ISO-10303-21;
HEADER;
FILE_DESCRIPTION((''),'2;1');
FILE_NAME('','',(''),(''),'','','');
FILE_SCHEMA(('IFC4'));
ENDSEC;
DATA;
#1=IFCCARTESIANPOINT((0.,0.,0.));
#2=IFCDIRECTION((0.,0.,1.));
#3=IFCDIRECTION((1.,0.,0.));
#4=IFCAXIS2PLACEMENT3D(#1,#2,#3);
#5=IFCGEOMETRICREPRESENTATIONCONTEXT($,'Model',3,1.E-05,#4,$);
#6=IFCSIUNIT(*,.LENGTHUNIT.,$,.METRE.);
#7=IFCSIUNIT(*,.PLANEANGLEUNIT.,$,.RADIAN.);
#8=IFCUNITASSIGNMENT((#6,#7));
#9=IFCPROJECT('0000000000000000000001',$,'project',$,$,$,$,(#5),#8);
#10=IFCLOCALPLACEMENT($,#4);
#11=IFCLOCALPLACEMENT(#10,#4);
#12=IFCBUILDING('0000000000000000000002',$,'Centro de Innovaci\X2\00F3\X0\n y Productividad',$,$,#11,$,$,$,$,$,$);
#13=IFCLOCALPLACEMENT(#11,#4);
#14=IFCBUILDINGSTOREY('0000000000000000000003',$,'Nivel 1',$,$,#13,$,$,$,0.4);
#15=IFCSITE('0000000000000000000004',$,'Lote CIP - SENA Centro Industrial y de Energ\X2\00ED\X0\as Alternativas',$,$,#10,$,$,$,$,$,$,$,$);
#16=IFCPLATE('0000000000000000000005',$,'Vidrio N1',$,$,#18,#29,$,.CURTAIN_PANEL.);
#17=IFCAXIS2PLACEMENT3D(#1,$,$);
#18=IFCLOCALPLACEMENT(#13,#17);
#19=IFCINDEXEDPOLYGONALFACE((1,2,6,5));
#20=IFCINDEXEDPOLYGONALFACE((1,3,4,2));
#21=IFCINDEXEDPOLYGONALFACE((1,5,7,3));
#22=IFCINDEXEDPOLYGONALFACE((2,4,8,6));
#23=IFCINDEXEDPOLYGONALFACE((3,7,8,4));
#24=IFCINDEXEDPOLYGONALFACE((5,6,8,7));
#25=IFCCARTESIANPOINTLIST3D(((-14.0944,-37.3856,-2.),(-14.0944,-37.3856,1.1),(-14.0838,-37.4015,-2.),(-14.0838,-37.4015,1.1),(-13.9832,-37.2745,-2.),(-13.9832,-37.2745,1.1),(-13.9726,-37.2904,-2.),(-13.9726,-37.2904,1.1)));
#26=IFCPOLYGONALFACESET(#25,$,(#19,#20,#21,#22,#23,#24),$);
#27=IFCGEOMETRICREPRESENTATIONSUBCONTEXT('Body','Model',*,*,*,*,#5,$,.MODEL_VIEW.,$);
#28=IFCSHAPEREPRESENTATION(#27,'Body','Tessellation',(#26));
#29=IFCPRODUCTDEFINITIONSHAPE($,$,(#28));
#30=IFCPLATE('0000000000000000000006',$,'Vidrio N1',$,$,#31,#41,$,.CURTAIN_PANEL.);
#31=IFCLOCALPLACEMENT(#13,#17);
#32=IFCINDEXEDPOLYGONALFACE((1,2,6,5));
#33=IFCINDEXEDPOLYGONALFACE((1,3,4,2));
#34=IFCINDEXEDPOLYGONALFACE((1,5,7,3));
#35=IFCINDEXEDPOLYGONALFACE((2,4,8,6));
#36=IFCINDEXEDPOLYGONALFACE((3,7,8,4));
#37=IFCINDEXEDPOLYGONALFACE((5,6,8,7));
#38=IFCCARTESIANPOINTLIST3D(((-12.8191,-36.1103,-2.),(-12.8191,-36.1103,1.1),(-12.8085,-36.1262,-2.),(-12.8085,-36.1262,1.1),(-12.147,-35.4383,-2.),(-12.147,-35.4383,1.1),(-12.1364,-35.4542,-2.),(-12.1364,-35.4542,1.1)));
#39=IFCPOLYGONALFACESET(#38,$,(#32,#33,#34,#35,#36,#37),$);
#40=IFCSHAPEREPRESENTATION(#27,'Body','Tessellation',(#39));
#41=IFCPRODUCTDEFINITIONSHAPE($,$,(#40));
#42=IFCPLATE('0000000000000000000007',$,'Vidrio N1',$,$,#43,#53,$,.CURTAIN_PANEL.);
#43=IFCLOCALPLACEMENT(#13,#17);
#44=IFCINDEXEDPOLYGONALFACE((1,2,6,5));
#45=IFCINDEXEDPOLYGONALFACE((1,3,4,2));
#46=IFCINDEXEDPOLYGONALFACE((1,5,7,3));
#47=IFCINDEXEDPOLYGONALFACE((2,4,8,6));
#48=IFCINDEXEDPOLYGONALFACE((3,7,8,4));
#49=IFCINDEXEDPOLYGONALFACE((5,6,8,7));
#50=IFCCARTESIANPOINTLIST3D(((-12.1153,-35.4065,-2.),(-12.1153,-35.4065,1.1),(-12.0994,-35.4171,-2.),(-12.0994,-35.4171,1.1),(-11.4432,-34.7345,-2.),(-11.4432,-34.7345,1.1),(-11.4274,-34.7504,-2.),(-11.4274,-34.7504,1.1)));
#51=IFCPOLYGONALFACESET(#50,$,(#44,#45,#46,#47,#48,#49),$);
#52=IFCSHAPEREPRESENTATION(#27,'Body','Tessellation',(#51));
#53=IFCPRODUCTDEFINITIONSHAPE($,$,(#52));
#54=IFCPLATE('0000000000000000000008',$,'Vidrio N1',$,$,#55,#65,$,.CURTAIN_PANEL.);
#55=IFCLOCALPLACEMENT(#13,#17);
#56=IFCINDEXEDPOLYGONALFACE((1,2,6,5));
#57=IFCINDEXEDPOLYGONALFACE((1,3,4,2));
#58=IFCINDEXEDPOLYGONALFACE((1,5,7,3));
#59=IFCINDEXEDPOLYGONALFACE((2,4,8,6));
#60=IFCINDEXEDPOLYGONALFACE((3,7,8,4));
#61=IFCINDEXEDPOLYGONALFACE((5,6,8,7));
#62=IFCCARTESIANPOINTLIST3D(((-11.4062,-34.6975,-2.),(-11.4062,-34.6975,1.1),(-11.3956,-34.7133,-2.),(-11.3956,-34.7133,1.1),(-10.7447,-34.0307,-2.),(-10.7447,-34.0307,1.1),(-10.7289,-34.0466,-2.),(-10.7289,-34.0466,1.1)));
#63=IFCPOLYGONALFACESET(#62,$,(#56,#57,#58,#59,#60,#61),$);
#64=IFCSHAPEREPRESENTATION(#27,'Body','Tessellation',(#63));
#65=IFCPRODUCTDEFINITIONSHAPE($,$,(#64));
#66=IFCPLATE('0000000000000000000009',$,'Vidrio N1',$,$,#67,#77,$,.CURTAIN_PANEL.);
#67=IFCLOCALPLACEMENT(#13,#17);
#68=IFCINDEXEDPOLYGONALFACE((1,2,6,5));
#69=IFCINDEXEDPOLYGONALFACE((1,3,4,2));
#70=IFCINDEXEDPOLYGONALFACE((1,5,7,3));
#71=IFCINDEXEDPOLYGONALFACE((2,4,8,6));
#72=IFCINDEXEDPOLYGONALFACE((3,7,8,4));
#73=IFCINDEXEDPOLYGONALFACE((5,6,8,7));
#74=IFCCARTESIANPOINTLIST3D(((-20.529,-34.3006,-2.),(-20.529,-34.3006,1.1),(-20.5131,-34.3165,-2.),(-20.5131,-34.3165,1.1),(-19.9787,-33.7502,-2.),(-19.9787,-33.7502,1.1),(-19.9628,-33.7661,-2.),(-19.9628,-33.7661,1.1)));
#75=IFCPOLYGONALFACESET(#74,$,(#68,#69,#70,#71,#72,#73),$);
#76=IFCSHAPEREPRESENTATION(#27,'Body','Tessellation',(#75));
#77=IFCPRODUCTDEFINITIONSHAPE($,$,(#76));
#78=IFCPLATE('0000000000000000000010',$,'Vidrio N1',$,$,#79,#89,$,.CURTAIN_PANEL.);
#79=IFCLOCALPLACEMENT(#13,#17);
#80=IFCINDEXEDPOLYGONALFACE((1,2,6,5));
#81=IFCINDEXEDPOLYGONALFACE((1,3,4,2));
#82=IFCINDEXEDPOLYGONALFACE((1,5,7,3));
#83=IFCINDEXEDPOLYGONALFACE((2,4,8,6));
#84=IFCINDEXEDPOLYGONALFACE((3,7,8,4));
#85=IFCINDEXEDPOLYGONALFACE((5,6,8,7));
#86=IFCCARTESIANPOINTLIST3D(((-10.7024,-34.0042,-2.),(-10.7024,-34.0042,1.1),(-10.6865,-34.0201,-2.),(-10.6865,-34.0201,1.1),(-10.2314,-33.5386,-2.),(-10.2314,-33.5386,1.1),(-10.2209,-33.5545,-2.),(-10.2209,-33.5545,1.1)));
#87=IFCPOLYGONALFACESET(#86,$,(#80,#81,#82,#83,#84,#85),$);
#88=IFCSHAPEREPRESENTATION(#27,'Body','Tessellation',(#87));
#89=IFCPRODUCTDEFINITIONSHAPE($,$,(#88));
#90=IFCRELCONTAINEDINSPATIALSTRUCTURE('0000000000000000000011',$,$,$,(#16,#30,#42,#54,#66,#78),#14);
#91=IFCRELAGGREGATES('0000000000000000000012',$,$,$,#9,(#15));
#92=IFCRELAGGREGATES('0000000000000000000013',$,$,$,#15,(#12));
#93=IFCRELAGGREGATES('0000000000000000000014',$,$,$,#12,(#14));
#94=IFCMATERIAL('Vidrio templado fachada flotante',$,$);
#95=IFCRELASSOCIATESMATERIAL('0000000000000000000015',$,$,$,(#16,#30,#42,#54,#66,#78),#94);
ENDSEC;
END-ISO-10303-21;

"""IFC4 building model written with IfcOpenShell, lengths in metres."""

from ifc_helpers import new_model, si_unit, frame, origin_with_axes, place, context, subcontext, project, spatial, polyline, outline, extrude, material, element, save


model = new_model("IFC4")

# Units and contexts
model_context = context("Model", 3, precision=1e-05, world=origin_with_axes())
body_context = subcontext(model_context, "Body", "Model", "MODEL_VIEW")
ifc_project = project(units=[si_unit("LENGTHUNIT", "METRE"), si_unit("PLANEANGLEUNIT", "RADIAN")], contexts=[model_context])

# Site, building, storey
site_placement = place(None, origin_with_axes())
site = spatial("IfcSite", under=ifc_project, at=site_placement, Name="Lote CIP - SENA Centro Industrial y de Energías Alternativas")
building_placement = place(site_placement, origin_with_axes())
building = spatial("IfcBuilding", under=site, at=building_placement, Name="Centro de Innovación y Productividad")
storey_placement = place(building_placement, origin_with_axes())
storey = spatial("IfcBuildingStorey", under=building, at=storey_placement, Name="Nivel 1", Elevation=0.4)

# Plates
ifc_material = material(Name="Vidrio templado fachada flotante")
plate_1_placement = place(storey_placement, frame((0.0, 0.0, -2.4), z_axis=(0.0, 0.0, 1.0), x_axis=(1.0, 0.0, 0.0)))
element("IfcPlate", 1, at=plate_1_placement, inside=storey, material=ifc_material, Name="Vidrio N1", PredefinedType="CURTAIN_PANEL", context=body_context, shape_type="SweptSolid", body=[
    extrude(outline(polyline([(-14.0838, -37.4015), (-14.0944, -37.3856), (-13.9832, -37.2745), (-13.9726, -37.2904), (-14.0838, -37.4015)])), frame((0.0, 0.0, 0.4)), (0.0, 0.0, 1.0), 3.1),
])
plate_2_placement = place(storey_placement, frame((0.0, 0.0, -2.4), z_axis=(0.0, 0.0, 1.0), x_axis=(1.0, 0.0, 0.0)))
element("IfcPlate", 2, at=plate_2_placement, inside=storey, material=ifc_material, Name="Vidrio N1", PredefinedType="CURTAIN_PANEL", context=body_context, shape_type="SweptSolid", body=[
    extrude(outline(polyline([(-12.1364, -35.4542), (-12.8085, -36.1262), (-12.8191, -36.1103), (-12.147, -35.4383), (-12.1364, -35.4542)])), frame((0.0, 0.0, 0.4)), (0.0, 0.0, 1.0), 3.1),
])
plate_3_placement = place(storey_placement, frame((0.0, 0.0, -2.4), z_axis=(0.0, 0.0, 1.0), x_axis=(1.0, 0.0, 0.0)))
element("IfcPlate", 3, at=plate_3_placement, inside=storey, material=ifc_material, Name="Vidrio N1", PredefinedType="CURTAIN_PANEL", context=body_context, shape_type="SweptSolid", body=[
    extrude(outline(polyline([(-11.4274, -34.7504), (-12.0994, -35.4171), (-12.1153, -35.4065), (-11.4432, -34.7345), (-11.4274, -34.7504)])), frame((0.0, 0.0, 0.4)), (0.0, 0.0, 1.0), 3.1),
])
plate_4_placement = place(storey_placement, frame((0.0, 0.0, -2.4), z_axis=(0.0, 0.0, 1.0), x_axis=(1.0, 0.0, 0.0)))
element("IfcPlate", 4, at=plate_4_placement, inside=storey, material=ifc_material, Name="Vidrio N1", PredefinedType="CURTAIN_PANEL", context=body_context, shape_type="SweptSolid", body=[
    extrude(outline(polyline([(-10.7289, -34.0466), (-11.3956, -34.7133), (-11.4062, -34.6975), (-10.7447, -34.0307), (-10.7289, -34.0466)])), frame((0.0, 0.0, 0.4)), (0.0, 0.0, 1.0), 3.1),
])
plate_5_placement = place(storey_placement, frame((0.0, 0.0, -2.4), z_axis=(0.0, 0.0, 1.0), x_axis=(1.0, 0.0, 0.0)))
element("IfcPlate", 5, at=plate_5_placement, inside=storey, material=ifc_material, Name="Vidrio N1", PredefinedType="CURTAIN_PANEL", context=body_context, shape_type="SweptSolid", body=[
    extrude(outline(polyline([(-20.5131, -34.3165), (-20.529, -34.3006), (-19.9787, -33.7502), (-19.9628, -33.7661), (-20.5131, -34.3165)])), frame((0.0, 0.0, 0.4)), (0.0, 0.0, 1.0), 3.1),
])
plate_6_placement = place(storey_placement, frame((0.0, 0.0, -2.4), z_axis=(0.0, 0.0, 1.0), x_axis=(1.0, 0.0, 0.0)))
element("IfcPlate", 6, at=plate_6_placement, inside=storey, material=ifc_material, Name="Vidrio N1", PredefinedType="CURTAIN_PANEL", context=body_context, shape_type="SweptSolid", body=[
    extrude(outline(polyline([(-10.6865, -34.0201), (-10.7024, -34.0042), (-10.2314, -33.5386), (-10.2209, -33.5545), (-10.6865, -34.0201)])), frame((0.0, 0.0, 0.4)), (0.0, 0.0, 1.0), 3.1),
])

save(model, "model.ifc")
